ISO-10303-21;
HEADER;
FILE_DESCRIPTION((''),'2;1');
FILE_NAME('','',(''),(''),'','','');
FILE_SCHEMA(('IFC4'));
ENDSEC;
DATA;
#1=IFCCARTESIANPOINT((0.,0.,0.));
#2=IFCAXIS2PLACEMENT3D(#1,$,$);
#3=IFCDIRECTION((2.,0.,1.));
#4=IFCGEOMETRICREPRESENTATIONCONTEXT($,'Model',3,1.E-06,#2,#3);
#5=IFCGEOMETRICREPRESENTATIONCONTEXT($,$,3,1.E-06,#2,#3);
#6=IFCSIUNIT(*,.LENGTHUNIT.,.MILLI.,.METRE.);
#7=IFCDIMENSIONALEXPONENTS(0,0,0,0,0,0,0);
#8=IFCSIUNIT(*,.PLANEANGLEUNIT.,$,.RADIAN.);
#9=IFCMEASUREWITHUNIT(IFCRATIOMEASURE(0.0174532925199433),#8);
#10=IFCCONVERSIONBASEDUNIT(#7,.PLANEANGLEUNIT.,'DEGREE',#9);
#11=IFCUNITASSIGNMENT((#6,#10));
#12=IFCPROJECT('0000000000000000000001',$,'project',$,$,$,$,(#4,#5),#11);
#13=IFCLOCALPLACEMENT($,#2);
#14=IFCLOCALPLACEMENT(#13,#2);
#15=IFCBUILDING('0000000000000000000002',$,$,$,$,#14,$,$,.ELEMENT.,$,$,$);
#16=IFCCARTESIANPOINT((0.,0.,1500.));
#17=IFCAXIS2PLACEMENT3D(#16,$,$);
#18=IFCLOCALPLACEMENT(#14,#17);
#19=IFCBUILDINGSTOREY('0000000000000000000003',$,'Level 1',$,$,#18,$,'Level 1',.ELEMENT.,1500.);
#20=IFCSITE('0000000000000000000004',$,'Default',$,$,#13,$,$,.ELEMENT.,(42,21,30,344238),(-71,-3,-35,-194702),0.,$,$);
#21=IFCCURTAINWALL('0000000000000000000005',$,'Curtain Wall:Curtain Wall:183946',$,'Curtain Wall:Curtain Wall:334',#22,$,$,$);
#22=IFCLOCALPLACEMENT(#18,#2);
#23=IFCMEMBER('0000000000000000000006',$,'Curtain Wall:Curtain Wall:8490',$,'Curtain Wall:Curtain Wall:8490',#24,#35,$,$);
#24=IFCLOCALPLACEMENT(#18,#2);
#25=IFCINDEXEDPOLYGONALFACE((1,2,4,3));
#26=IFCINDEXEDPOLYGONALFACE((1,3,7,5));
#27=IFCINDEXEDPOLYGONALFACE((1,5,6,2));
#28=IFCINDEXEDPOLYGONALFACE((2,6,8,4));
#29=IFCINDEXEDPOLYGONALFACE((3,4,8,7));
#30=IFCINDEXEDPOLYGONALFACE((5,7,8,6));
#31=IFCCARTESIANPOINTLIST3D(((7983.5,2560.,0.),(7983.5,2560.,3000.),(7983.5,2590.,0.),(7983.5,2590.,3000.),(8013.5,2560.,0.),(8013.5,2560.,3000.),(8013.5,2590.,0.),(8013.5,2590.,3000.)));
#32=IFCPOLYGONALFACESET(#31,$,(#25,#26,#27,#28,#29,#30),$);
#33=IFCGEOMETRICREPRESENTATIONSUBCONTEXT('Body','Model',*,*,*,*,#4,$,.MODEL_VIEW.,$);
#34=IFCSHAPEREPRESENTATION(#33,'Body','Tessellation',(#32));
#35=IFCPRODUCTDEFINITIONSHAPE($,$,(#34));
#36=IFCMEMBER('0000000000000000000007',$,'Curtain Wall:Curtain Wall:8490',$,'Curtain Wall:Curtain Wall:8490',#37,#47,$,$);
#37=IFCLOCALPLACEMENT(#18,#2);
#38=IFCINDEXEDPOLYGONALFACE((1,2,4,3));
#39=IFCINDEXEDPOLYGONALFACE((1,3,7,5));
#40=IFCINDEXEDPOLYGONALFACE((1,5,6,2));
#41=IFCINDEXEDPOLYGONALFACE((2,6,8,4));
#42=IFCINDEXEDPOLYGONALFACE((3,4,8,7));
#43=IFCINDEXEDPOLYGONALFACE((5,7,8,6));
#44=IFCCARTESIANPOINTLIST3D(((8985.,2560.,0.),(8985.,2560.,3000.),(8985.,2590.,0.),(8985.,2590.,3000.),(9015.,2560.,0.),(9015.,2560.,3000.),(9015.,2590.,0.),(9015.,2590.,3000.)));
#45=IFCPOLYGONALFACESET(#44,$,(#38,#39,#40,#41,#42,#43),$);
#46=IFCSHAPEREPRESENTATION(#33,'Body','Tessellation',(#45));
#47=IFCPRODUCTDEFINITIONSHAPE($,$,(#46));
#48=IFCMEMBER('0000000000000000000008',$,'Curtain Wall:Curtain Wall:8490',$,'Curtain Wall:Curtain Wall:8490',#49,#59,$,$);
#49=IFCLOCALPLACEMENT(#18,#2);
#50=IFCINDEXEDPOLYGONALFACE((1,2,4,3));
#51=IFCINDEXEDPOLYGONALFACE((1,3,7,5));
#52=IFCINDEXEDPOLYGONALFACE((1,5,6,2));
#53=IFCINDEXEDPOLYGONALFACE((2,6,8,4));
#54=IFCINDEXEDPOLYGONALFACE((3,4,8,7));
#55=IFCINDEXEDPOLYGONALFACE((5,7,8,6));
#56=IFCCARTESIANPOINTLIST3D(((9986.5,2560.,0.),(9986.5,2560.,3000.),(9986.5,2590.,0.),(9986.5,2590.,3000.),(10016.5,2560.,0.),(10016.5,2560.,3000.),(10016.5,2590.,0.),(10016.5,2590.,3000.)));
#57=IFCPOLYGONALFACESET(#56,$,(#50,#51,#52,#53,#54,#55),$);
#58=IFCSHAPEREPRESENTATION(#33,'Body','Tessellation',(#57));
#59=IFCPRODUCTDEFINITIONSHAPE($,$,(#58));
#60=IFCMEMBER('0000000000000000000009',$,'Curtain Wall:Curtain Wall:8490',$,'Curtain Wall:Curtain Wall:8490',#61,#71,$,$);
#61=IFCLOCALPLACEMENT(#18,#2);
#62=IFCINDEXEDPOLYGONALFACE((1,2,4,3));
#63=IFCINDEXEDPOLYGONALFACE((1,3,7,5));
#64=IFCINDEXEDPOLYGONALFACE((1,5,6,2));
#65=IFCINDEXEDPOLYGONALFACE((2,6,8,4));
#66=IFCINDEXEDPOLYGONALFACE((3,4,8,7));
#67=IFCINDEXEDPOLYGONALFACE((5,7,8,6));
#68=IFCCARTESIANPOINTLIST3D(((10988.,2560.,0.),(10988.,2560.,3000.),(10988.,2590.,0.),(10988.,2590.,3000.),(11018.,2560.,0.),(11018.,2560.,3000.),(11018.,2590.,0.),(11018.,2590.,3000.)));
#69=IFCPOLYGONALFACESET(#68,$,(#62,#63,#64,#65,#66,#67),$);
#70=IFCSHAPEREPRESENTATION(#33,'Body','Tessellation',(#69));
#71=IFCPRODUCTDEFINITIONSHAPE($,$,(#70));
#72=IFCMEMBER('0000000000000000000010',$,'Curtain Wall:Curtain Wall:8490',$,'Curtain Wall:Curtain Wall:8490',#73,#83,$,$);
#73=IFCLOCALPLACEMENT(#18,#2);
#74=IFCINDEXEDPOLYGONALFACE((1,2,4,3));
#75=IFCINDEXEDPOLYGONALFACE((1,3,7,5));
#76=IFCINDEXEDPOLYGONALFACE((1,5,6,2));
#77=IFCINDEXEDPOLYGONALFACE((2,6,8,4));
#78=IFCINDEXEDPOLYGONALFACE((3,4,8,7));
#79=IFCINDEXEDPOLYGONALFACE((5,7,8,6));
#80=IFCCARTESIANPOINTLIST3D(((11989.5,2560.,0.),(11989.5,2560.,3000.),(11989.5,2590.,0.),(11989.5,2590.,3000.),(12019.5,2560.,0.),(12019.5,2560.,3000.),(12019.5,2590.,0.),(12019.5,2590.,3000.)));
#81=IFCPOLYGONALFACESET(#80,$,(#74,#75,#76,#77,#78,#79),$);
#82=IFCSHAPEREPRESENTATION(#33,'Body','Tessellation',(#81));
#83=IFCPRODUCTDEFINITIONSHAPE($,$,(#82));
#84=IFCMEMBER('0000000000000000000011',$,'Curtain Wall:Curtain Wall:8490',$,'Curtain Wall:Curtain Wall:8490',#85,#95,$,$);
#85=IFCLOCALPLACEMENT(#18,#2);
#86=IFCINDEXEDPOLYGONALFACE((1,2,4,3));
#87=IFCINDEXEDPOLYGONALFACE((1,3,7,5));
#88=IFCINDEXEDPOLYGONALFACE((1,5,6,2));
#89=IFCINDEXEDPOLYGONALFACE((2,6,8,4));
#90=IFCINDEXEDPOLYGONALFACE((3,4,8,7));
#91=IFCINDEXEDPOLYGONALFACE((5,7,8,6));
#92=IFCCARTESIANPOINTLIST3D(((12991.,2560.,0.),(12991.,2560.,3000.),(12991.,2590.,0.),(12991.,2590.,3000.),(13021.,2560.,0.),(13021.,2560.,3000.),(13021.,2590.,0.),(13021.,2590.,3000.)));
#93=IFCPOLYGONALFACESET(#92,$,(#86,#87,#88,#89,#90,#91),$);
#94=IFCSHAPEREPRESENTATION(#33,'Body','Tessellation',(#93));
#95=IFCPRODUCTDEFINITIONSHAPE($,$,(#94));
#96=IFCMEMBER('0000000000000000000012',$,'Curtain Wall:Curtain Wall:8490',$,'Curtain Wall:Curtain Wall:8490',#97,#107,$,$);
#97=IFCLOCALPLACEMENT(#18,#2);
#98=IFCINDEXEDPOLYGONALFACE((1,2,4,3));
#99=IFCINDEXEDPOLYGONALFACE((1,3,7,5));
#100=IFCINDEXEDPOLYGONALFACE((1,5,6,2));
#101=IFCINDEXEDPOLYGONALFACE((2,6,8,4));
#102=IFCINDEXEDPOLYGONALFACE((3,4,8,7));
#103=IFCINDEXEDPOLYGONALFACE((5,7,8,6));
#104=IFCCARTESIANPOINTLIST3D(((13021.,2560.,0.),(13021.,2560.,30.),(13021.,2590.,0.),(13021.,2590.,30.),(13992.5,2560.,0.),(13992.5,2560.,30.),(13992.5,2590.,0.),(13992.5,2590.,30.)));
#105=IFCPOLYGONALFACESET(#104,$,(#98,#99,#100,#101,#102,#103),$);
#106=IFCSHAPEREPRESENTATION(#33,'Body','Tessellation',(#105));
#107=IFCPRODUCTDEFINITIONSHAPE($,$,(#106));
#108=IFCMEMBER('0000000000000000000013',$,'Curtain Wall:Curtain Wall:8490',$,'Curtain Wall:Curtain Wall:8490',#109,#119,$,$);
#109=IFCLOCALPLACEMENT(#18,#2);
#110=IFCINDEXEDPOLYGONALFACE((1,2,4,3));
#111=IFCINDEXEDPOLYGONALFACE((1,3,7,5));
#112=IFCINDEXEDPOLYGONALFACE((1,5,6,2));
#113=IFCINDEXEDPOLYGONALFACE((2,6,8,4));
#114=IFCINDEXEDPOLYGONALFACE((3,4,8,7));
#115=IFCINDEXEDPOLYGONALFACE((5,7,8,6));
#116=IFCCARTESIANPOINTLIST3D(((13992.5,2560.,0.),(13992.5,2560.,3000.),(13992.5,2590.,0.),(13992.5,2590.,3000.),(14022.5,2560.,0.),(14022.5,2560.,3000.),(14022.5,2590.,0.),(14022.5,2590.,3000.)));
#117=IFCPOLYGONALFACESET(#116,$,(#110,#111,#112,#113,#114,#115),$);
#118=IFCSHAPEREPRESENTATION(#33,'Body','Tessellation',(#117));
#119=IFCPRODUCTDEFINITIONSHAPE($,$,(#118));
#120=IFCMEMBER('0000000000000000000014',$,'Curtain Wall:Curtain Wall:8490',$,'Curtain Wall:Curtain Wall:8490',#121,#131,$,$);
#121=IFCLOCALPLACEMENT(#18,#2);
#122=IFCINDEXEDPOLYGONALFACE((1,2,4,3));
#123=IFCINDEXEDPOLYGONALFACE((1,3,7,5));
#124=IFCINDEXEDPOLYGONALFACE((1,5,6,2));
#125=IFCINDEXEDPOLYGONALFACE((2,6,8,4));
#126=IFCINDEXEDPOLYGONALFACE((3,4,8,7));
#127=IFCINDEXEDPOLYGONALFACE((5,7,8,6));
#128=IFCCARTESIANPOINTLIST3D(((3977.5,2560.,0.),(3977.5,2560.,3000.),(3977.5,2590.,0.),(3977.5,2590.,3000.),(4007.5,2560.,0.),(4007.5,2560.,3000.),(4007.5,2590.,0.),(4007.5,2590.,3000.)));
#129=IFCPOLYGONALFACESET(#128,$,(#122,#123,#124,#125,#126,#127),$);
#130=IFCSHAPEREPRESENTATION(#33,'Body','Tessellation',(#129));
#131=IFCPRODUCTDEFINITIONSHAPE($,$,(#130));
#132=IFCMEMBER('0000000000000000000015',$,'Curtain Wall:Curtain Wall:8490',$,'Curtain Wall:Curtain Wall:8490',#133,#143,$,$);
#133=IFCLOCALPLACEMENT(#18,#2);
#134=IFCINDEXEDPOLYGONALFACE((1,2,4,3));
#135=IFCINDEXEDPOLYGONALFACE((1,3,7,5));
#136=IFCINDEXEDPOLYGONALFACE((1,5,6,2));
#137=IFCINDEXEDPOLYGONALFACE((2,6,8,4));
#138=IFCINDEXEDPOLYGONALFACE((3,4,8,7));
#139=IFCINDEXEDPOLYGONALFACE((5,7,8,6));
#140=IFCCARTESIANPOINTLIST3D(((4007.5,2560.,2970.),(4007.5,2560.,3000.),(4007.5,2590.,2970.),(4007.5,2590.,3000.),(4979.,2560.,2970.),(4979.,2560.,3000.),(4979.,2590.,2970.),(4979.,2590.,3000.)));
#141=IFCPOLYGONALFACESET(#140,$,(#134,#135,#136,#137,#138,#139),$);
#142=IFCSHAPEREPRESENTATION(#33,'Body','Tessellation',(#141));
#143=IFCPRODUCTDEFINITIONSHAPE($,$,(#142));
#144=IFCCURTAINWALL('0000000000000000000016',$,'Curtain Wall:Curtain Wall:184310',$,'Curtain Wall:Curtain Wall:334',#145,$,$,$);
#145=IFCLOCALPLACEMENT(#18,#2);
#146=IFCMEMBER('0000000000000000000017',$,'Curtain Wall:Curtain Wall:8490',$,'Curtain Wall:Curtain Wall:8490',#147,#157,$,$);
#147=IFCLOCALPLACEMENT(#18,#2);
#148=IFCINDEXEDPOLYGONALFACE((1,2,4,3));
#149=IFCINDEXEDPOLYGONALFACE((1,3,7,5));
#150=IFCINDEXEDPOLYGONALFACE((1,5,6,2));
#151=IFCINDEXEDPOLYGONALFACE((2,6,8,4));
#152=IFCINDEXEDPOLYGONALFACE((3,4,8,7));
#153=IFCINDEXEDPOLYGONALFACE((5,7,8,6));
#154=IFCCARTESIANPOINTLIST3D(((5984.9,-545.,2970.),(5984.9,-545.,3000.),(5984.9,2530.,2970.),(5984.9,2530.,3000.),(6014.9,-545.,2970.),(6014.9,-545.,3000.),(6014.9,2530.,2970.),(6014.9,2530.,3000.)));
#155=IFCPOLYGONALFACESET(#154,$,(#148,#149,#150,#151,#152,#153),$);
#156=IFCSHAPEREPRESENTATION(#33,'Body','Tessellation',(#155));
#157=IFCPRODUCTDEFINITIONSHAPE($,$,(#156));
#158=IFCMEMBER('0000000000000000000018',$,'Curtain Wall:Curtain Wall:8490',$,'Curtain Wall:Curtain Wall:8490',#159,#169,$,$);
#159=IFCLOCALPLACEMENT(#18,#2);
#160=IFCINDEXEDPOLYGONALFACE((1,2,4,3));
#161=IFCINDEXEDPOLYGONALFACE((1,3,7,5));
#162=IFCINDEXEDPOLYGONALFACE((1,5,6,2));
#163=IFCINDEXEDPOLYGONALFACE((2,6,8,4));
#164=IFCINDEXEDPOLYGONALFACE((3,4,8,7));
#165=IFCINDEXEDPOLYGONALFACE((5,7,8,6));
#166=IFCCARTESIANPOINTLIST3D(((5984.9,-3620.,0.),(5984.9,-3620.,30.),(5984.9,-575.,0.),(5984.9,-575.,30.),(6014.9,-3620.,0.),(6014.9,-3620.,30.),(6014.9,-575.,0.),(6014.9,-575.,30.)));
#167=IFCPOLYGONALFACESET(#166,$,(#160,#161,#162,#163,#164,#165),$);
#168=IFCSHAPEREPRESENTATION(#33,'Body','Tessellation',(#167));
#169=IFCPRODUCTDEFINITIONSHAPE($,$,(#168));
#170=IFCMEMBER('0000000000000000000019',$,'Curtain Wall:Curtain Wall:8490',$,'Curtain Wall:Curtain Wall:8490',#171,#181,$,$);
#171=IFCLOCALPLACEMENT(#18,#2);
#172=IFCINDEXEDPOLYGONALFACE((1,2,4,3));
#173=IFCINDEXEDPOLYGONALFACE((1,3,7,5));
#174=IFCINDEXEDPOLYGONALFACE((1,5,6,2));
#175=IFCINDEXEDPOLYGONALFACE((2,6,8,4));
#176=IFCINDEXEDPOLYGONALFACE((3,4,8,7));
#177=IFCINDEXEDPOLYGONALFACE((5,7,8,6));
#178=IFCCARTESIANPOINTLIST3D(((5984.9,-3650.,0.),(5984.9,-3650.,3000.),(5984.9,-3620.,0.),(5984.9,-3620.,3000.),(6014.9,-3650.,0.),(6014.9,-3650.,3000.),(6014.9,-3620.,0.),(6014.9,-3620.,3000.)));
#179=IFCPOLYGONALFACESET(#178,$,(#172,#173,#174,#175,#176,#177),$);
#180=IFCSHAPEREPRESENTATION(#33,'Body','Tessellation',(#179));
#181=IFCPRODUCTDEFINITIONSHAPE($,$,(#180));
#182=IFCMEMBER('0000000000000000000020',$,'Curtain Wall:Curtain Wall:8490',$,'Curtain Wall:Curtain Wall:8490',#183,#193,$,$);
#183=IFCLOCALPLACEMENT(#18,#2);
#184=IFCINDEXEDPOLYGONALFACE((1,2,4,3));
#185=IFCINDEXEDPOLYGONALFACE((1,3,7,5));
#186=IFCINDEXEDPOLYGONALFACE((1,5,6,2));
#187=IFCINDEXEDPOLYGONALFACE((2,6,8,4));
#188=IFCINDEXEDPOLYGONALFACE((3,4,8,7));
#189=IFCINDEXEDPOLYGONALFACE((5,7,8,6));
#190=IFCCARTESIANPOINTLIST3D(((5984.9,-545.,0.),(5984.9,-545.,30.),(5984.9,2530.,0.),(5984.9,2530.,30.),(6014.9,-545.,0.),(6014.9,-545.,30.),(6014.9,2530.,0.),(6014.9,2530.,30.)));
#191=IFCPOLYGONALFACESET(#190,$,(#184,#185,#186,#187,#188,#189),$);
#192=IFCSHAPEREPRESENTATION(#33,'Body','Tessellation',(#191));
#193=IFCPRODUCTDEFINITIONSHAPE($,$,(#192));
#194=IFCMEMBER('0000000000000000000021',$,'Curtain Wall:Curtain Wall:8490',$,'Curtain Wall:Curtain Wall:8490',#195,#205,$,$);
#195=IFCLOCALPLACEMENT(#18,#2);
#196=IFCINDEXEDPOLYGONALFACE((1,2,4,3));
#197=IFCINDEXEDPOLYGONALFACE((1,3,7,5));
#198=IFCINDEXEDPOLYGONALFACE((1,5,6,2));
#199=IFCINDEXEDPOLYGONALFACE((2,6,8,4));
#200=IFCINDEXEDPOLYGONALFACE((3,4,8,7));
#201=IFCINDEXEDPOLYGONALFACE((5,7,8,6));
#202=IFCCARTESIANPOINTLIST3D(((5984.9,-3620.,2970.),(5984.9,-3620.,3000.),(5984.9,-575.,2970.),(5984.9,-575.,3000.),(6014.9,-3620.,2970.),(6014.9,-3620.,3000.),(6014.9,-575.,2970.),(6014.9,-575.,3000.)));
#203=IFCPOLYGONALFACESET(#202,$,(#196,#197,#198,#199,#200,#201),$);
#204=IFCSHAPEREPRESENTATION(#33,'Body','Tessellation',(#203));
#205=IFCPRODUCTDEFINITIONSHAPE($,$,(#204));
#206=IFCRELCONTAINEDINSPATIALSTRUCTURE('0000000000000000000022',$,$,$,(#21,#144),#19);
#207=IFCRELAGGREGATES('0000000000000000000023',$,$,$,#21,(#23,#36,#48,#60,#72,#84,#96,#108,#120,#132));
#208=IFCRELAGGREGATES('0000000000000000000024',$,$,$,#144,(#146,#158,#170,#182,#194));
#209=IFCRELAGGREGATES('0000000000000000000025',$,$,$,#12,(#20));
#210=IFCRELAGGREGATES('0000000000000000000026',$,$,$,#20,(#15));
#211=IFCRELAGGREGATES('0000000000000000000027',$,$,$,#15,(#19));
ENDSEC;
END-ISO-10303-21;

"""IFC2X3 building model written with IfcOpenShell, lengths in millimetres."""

from ifc_helpers import new_model, entity, si_unit, converted_unit, direction, frame, frame_2d, origin, origin_2d_with_axis, place, context, subcontext, project, spatial, rectangle, extrude, element, aggregate, save


model = new_model("IFC2X3")

# Units and contexts
model_context = context("Model", 3, precision=1e-06, world=origin(), true_north=direction((2.0, 0.0, 1.0)))
context_of_model = context(None, 3, precision=1e-06, world=origin(), true_north=direction((2.0, 0.0, 1.0)))
body_context = subcontext(model_context, "Body", "Model", "MODEL_VIEW")
ifc_project = project(units=[si_unit("LENGTHUNIT", "METRE", prefix="MILLI"), converted_unit("PLANEANGLEUNIT", "DEGREE", entity("IfcRatioMeasure", 0.0174532925199433), si_unit("PLANEANGLEUNIT", "RADIAN"), dimensions=[0, 0, 0, 0, 0, 0, 0])], contexts=[model_context, context_of_model])

# Site, building, storey
site_placement = place(None, origin())
site = spatial("IfcSite", under=ifc_project, at=site_placement, Name="Default", CompositionType="ELEMENT", RefLatitude=(42, 21, 30, 344238), RefLongitude=(-71, -3, -35, -194702), RefElevation=0.0)
building_placement = place(site_placement, origin())
building = spatial("IfcBuilding", under=site, at=building_placement, CompositionType="ELEMENT")
storey_placement = place(building_placement, frame((0.0, 0.0, 1500.0)))
storey = spatial("IfcBuildingStorey", under=building, at=storey_placement, Name="Level 1", LongName="Level 1", CompositionType="ELEMENT", Elevation=1500.0)

# Curtain walls, members
curtain_wall_1_placement = place(storey_placement, origin())
curtain_wall_1 = element("IfcCurtainWall", 1, at=curtain_wall_1_placement, inside=storey, Name="Curtain Wall:Curtain Wall:183946", ObjectType="Curtain Wall:Curtain Wall:334")
member_1_placement = place(storey_placement, origin())
member_1 = element("IfcMember", 2, at=member_1_placement, Name="Curtain Wall:Curtain Wall:8490", ObjectType="Curtain Wall:Curtain Wall:8490", context=body_context, shape_type="SweptSolid", body=[
    extrude(rectangle(XDim=30.0, YDim=30.0, at=frame_2d((0.0, 0.0), x_axis=(1.0, 0.0))), frame((7998.5, 2575.0, 0.0), z_axis=(0.0, 0.0, 1.0), x_axis=(0.0, -1.0, 0.0)), (0.0, 0.0, 1.0), 3000.0),
])
member_2_placement = place(storey_placement, origin())
member_2 = element("IfcMember", 3, at=member_2_placement, Name="Curtain Wall:Curtain Wall:8490", ObjectType="Curtain Wall:Curtain Wall:8490", context=body_context, shape_type="SweptSolid", body=[
    extrude(rectangle(XDim=30.0, YDim=30.0, at=frame_2d((0.0, 0.0), x_axis=(1.0, 0.0))), frame((9000.0, 2575.0, 0.0), z_axis=(0.0, 0.0, 1.0), x_axis=(0.0, -1.0, 0.0)), (0.0, 0.0, 1.0), 3000.0),
])
member_3_placement = place(storey_placement, origin())
member_3 = element("IfcMember", 4, at=member_3_placement, Name="Curtain Wall:Curtain Wall:8490", ObjectType="Curtain Wall:Curtain Wall:8490", context=body_context, shape_type="SweptSolid", body=[
    extrude(rectangle(XDim=30.0, YDim=30.0, at=frame_2d((0.0, 0.0), x_axis=(1.0, 0.0))), frame((10001.5, 2575.0, 0.0), z_axis=(0.0, 0.0, 1.0), x_axis=(0.0, -1.0, 0.0)), (0.0, 0.0, 1.0), 3000.0),
])
member_4_placement = place(storey_placement, origin())
member_4 = element("IfcMember", 5, at=member_4_placement, Name="Curtain Wall:Curtain Wall:8490", ObjectType="Curtain Wall:Curtain Wall:8490", context=body_context, shape_type="SweptSolid", body=[
    extrude(rectangle(XDim=30.0, YDim=30.0, at=frame_2d((0.0, 0.0), x_axis=(1.0, 0.0))), frame((11003.0, 2575.0, 0.0), z_axis=(0.0, 0.0, 1.0), x_axis=(0.0, -1.0, 0.0)), (0.0, 0.0, 1.0), 3000.0),
])
member_5_placement = place(storey_placement, origin())
member_5 = element("IfcMember", 6, at=member_5_placement, Name="Curtain Wall:Curtain Wall:8490", ObjectType="Curtain Wall:Curtain Wall:8490", context=body_context, shape_type="SweptSolid", body=[
    extrude(rectangle(XDim=30.0, YDim=30.0, at=frame_2d((0.0, 0.0), x_axis=(1.0, 0.0))), frame((12004.5, 2575.0, 0.0), z_axis=(0.0, 0.0, 1.0), x_axis=(0.0, -1.0, 0.0)), (0.0, 0.0, 1.0), 3000.0),
])
member_6_placement = place(storey_placement, origin())
member_6 = element("IfcMember", 7, at=member_6_placement, Name="Curtain Wall:Curtain Wall:8490", ObjectType="Curtain Wall:Curtain Wall:8490", context=body_context, shape_type="SweptSolid", body=[
    extrude(rectangle(XDim=30.0, YDim=30.0, at=frame_2d((0.0, 0.0), x_axis=(1.0, 0.0))), frame((13006.0, 2575.0, 0.0), z_axis=(0.0, 0.0, 1.0), x_axis=(0.0, -1.0, 0.0)), (0.0, 0.0, 1.0), 3000.0),
])
member_7_placement = place(storey_placement, origin())
member_7 = element("IfcMember", 8, at=member_7_placement, Name="Curtain Wall:Curtain Wall:8490", ObjectType="Curtain Wall:Curtain Wall:8490", context=body_context, shape_type="SweptSolid", body=[
    extrude(rectangle(XDim=971.5, YDim=30.0, at=frame_2d((0.0, 0.0), x_axis=(1.0, 0.0))), frame((13506.8, 2575.0, 0.0), z_axis=(0.0, 0.0, 1.0), x_axis=(-1.0, 0.0, 0.0)), (0.0, 0.0, 1.0), 30.0),
])
member_8_placement = place(storey_placement, origin())
member_8 = element("IfcMember", 9, at=member_8_placement, Name="Curtain Wall:Curtain Wall:8490", ObjectType="Curtain Wall:Curtain Wall:8490", context=body_context, shape_type="SweptSolid", body=[
    extrude(rectangle(XDim=30.0, YDim=30.0, at=frame_2d((0.0, 0.0), x_axis=(1.0, 0.0))), frame((14007.5, 2575.0, 0.0), z_axis=(0.0, 0.0, 1.0), x_axis=(-1.0, 0.0, 0.0)), (0.0, 0.0, 1.0), 3000.0),
])
member_9_placement = place(storey_placement, origin())
member_9 = element("IfcMember", 10, at=member_9_placement, Name="Curtain Wall:Curtain Wall:8490", ObjectType="Curtain Wall:Curtain Wall:8490", context=body_context, shape_type="SweptSolid", body=[
    extrude(rectangle(XDim=30.0, YDim=30.0, at=frame_2d((0.0, 0.0), x_axis=(1.0, 0.0))), frame((3992.5, 2575.0, 0.0), z_axis=(0.0, 0.0, 1.0), x_axis=(0.0, -1.0, 0.0)), (0.0, 0.0, 1.0), 3000.0),
])
member_10_placement = place(storey_placement, origin())
member_10 = element("IfcMember", 11, at=member_10_placement, Name="Curtain Wall:Curtain Wall:8490", ObjectType="Curtain Wall:Curtain Wall:8490", context=body_context, shape_type="SweptSolid", body=[
    extrude(rectangle(XDim=971.5, YDim=30.0, at=frame_2d((0.0, 0.0), x_axis=(1.0, 0.0))), frame((4493.2, 2575.0, 2970.0)), (0.0, 0.0, 1.0), 30.0),
])
aggregate(curtain_wall_1, [member_1, member_2, member_3, member_4, member_5, member_6, member_7, member_8, member_9, member_10])
curtain_wall_2_placement = place(storey_placement, origin())
curtain_wall_2 = element("IfcCurtainWall", 12, at=curtain_wall_2_placement, inside=storey, Name="Curtain Wall:Curtain Wall:184310", ObjectType="Curtain Wall:Curtain Wall:334")
member_11_placement = place(storey_placement, origin())
member_11 = element("IfcMember", 13, at=member_11_placement, Name="Curtain Wall:Curtain Wall:8490", ObjectType="Curtain Wall:Curtain Wall:8490", context=body_context, shape_type="SweptSolid", body=[
    extrude(rectangle(XDim=3075.0, YDim=30.0, at=origin_2d_with_axis()), frame((5999.9, 992.5, 2970.0), z_axis=(0.0, 0.0, 1.0), x_axis=(0.0, 1.0, 0.0)), (0.0, 0.0, 1.0), 30.0),
])
member_12_placement = place(storey_placement, origin())
member_12 = element("IfcMember", 14, at=member_12_placement, Name="Curtain Wall:Curtain Wall:8490", ObjectType="Curtain Wall:Curtain Wall:8490", context=body_context, shape_type="SweptSolid", body=[
    extrude(rectangle(XDim=3045.0, YDim=30.0, at=frame_2d((0.0, 0.0), x_axis=(1.0, 0.0))), frame((5999.9, -2097.5, 0.0), z_axis=(0.0, 0.0, 1.0), x_axis=(0.0, -1.0, 0.0)), (0.0, 0.0, 1.0), 30.0),
])
member_13_placement = place(storey_placement, origin())
member_13 = element("IfcMember", 15, at=member_13_placement, Name="Curtain Wall:Curtain Wall:8490", ObjectType="Curtain Wall:Curtain Wall:8490", context=body_context, shape_type="SweptSolid", body=[
    extrude(rectangle(XDim=30.0, YDim=30.0, at=frame_2d((0.0, 0.0), x_axis=(1.0, 0.0))), frame((5999.9, -3635.0, 0.0)), (0.0, 0.0, 1.0), 3000.0),
])
member_14_placement = place(storey_placement, origin())
member_14 = element("IfcMember", 16, at=member_14_placement, Name="Curtain Wall:Curtain Wall:8490", ObjectType="Curtain Wall:Curtain Wall:8490", context=body_context, shape_type="SweptSolid", body=[
    extrude(rectangle(XDim=3075.0, YDim=30.0, at=origin_2d_with_axis()), frame((5999.9, 992.5, 0.0), z_axis=(0.0, 0.0, 1.0), x_axis=(0.0, -1.0, 0.0)), (0.0, 0.0, 1.0), 30.0),
])
member_15_placement = place(storey_placement, origin())
member_15 = element("IfcMember", 17, at=member_15_placement, Name="Curtain Wall:Curtain Wall:8490", ObjectType="Curtain Wall:Curtain Wall:8490", context=body_context, shape_type="SweptSolid", body=[
    extrude(rectangle(XDim=3045.0, YDim=30.0, at=origin_2d_with_axis()), frame((5999.9, -2097.5, 2970.0), z_axis=(0.0, 0.0, 1.0), x_axis=(0.0, 1.0, 0.0)), (0.0, 0.0, 1.0), 30.0),
])
aggregate(curtain_wall_2, [member_11, member_12, member_13, member_14, member_15])

save(model, "model.ifc")
